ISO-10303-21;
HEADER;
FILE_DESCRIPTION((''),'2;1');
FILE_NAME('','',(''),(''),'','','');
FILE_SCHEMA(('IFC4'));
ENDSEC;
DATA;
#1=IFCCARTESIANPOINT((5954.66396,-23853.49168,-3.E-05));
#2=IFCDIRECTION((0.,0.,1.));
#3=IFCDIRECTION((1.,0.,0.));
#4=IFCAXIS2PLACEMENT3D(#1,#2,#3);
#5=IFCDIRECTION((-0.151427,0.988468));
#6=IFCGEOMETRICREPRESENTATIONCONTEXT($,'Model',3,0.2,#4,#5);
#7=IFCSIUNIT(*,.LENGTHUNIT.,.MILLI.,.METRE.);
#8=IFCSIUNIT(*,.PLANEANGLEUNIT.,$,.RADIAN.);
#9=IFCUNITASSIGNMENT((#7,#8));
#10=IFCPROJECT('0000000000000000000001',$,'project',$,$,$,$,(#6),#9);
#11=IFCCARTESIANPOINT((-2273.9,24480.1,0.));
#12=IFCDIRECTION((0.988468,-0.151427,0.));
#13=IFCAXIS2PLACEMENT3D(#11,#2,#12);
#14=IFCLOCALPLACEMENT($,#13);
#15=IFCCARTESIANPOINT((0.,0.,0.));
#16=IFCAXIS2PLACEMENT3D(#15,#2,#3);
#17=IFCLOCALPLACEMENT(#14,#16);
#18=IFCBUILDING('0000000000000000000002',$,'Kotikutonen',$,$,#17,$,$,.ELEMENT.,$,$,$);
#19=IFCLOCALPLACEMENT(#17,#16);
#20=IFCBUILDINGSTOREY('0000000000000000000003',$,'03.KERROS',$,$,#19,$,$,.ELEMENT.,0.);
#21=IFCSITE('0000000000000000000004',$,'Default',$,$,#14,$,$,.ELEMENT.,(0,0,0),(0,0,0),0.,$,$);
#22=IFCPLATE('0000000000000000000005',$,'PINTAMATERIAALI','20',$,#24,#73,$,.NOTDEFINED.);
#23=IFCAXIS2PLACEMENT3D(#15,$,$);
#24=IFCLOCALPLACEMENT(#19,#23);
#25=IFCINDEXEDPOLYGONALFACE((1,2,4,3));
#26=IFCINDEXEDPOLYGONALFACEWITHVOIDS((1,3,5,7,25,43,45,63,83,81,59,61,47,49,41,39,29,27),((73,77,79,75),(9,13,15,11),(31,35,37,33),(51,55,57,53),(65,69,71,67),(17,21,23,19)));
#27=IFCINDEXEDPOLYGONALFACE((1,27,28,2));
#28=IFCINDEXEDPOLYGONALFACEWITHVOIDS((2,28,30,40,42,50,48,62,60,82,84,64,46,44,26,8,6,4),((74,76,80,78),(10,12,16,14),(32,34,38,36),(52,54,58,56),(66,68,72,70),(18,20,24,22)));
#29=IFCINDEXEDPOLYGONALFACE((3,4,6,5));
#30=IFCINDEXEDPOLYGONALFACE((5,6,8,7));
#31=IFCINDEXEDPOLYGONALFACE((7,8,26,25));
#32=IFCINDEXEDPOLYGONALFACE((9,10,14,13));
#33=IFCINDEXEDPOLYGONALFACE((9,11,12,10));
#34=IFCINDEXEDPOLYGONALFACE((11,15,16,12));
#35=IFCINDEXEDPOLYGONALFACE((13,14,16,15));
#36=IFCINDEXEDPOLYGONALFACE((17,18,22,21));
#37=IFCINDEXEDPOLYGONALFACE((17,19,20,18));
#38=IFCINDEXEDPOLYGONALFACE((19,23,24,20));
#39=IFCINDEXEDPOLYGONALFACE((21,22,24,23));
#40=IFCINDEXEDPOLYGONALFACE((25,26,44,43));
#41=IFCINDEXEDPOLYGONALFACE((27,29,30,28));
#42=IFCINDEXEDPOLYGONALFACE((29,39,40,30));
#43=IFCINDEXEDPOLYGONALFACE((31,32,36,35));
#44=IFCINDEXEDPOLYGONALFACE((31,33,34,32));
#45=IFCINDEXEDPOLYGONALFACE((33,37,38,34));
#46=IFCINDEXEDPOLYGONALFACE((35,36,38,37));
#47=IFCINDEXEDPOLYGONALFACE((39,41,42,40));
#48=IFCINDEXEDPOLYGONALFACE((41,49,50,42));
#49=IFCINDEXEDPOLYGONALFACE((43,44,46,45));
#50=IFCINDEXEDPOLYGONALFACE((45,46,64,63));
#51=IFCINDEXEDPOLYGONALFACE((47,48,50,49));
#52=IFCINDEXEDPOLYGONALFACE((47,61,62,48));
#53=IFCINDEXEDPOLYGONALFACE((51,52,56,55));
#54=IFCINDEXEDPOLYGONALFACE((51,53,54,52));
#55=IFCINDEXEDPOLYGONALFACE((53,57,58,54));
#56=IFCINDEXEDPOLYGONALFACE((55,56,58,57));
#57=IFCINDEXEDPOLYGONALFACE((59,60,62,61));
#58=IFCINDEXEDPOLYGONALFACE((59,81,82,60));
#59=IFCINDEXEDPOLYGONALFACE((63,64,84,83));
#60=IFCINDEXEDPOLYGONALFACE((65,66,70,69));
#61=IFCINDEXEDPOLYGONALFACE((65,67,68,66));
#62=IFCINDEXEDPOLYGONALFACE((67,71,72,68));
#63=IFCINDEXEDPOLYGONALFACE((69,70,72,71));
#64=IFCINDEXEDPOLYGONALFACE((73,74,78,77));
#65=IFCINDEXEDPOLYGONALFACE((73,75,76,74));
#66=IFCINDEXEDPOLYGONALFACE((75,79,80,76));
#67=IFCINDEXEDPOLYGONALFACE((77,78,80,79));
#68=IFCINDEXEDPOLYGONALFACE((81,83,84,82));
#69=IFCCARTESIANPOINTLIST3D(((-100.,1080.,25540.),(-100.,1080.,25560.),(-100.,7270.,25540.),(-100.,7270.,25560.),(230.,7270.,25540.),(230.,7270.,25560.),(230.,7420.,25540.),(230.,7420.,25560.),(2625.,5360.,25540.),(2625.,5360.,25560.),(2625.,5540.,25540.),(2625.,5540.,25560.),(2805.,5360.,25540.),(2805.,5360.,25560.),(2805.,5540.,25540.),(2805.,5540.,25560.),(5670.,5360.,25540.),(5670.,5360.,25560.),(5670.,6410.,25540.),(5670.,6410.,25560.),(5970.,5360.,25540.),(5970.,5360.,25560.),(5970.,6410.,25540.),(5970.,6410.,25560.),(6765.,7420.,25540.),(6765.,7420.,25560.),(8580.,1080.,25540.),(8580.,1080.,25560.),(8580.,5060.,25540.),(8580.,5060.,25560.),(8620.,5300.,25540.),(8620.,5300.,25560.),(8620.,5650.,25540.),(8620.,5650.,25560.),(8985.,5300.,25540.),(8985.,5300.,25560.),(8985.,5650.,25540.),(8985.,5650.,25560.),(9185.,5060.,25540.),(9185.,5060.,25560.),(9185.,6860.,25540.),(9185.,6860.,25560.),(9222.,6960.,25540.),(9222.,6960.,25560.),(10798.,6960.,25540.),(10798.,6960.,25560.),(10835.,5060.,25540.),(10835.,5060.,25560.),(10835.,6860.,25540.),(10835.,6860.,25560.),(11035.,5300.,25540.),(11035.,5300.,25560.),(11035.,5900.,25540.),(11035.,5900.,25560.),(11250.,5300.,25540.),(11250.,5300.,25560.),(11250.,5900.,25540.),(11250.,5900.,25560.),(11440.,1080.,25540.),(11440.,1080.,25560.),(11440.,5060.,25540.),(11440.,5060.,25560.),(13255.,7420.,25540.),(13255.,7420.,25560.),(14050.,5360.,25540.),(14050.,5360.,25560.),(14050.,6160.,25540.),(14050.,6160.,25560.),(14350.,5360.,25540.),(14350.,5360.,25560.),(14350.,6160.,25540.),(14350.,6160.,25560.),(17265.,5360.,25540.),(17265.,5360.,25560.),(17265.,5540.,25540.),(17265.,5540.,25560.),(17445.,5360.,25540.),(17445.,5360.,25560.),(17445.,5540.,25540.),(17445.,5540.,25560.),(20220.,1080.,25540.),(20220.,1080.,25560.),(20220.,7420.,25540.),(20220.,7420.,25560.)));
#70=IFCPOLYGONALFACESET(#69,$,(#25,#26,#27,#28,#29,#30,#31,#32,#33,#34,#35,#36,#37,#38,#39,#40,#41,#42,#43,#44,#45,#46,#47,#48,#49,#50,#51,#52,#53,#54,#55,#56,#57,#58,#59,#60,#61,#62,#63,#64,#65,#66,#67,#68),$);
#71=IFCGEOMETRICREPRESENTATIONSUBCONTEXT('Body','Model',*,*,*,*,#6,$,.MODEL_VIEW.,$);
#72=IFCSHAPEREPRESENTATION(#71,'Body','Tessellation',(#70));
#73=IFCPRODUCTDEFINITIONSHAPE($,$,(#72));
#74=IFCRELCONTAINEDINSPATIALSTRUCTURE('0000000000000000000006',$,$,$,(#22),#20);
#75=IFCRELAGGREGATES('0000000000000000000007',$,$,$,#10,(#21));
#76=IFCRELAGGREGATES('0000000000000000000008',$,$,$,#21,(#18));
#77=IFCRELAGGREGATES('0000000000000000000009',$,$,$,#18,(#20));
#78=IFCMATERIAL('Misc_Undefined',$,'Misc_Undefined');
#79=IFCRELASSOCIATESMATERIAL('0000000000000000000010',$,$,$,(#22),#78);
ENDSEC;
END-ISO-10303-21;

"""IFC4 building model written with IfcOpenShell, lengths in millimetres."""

from ifc_helpers import new_model, si_unit, direction, frame, origin_with_axes, place, context, subcontext, project, spatial, line, indexed_curve, outline, extrude, material, element, save


model = new_model("IFC4")

# Units and contexts
model_context = context("Model", 3, precision=0.2, world=frame((5954.66396, -23853.49168, -3e-05), z_axis=(0.0, 0.0, 1.0), x_axis=(1.0, 0.0, 0.0)), true_north=direction((-0.151427, 0.988468)))
body_context = subcontext(model_context, "Body", "Model", "MODEL_VIEW")
ifc_project = project(units=[si_unit("LENGTHUNIT", "METRE", prefix="MILLI"), si_unit("PLANEANGLEUNIT", "RADIAN")], contexts=[model_context])

# Site, building, storey
site_placement = place(None, frame((-2273.9, 24480.1, 0.0), z_axis=(0.0, 0.0, 1.0), x_axis=(0.988468, -0.151427, 0.0)))
site = spatial("IfcSite", under=ifc_project, at=site_placement, Name="Default", CompositionType="ELEMENT", RefLatitude=(0, 0, 0), RefLongitude=(0, 0, 0), RefElevation=0.0)
building_placement = place(site_placement, origin_with_axes())
building = spatial("IfcBuilding", under=site, at=building_placement, Name="Kotikutonen", CompositionType="ELEMENT")
storey_placement = place(building_placement, origin_with_axes())
storey = spatial("IfcBuildingStorey", under=building, at=storey_placement, Name="03.KERROS", CompositionType="ELEMENT", Elevation=0.0)

# Plate, voiding features
ifc_material_1 = material(Name="Misc_Undefined", Category="Misc_Undefined")
plate_placement = place(storey_placement, frame((-100.0, 7270.0, 25550.0), z_axis=(0.0, 0.0, 1.0), x_axis=(0.0, -1.0, 0.0)))
plate = element("IfcPlate", 1, at=plate_placement, inside=storey, material=ifc_material_1, Name="PINTAMATERIAALI", Description="20", PredefinedType="NOTDEFINED", context=body_context, shape_type="SolidModel", body=[
    extrude(outline(indexed_curve([(0.0, 0.0), (6190.0, 0.0), (6190.0, 8680.0), (7270.0, 8680.0), (7270.0, 11540.0), (6190.0, 11540.0), (6190.0, 20320.0), (-150.0, 20320.0), (-150.0, 13355.0), (310.0, 10898.0), (310.0, 9322.0), (-150.0, 6865.0), (-150.0, 330.0), (0.0, 330.0)], segments=[line(1, 2, 3, 4, 5, 6, 7, 8, 9, 10, 11, 12, 13, 14, 1)])), frame((0.0, 0.0, 10.0), z_axis=(0.0, 0.0, 1.0), x_axis=(1.0, 0.0, 0.0)), (0.0, 0.0, -1.0), 20.0),
])
voiding_feature_1_placement = place(plate_placement, frame((2210.0, 8680.0, 0.0), z_axis=(0.0, 0.0, 1.0), x_axis=(1.0, 0.0, 0.0)))
element("IfcVoidingFeature", 2, at=voiding_feature_1_placement, cuts=plate, Name="POLYGON CUT", PredefinedType="HOLE", context=body_context, shape_type="SolidModel", body=[
    extrude(outline(indexed_curve([(0.0, 0.0), (5060.0, 0.0), (5060.0, 2860.0), (0.0, 2860.0), (0.0, 2255.0), (-1800.0, 2255.0), (-1800.0, 605.0), (0.0, 605.0)], segments=[line(1, 2, 3, 4, 5, 6, 7, 8, 1)])), frame((0.0, 0.0, 85.0), z_axis=(0.0, 0.0, 1.0), x_axis=(1.0, 0.0, 0.0)), (0.0, 0.0, -1.0), 170.0),
])
voiding_feature_2_placement = place(plate_placement, frame((1620.0, 8720.0, 0.0), z_axis=(0.0, 0.0, 1.0), x_axis=(1.0, 0.0, 0.0)))
element("IfcVoidingFeature", 3, at=voiding_feature_2_placement, cuts=plate, Name="POLYGON CUT", PredefinedType="HOLE", context=body_context, shape_type="SolidModel", body=[
    extrude(outline(indexed_curve([(0.0, 0.0), (350.0, 0.0), (350.0, 365.0), (0.0, 365.0)], segments=[line(1, 2, 3, 4, 1)])), frame((0.0, 0.0, 85.0), z_axis=(0.0, 0.0, 1.0), x_axis=(1.0, 0.0, 0.0)), (0.0, 0.0, -1.0), 170.0),
])
voiding_feature_3_placement = place(plate_placement, frame((1370.0, 11135.0, 0.0), z_axis=(0.0, 0.0, 1.0), x_axis=(1.0, 0.0, 0.0)))
element("IfcVoidingFeature", 4, at=voiding_feature_3_placement, cuts=plate, Name="POLYGON CUT", PredefinedType="HOLE", context=body_context, shape_type="SolidModel", body=[
    extrude(outline(indexed_curve([(0.0, 0.0), (600.0, 0.0), (600.0, 215.0), (0.0, 215.0)], segments=[line(1, 2, 3, 4, 1)])), frame((0.0, 0.0, 85.0), z_axis=(0.0, 0.0, 1.0), x_axis=(1.0, 0.0, 0.0)), (0.0, 0.0, -1.0), 170.0),
])
voiding_feature_4_placement = place(plate_placement, frame((860.0, 5770.0, 0.0), z_axis=(0.0, 0.0, 1.0), x_axis=(1.0, 0.0, 0.0)))
element("IfcVoidingFeature", 5, at=voiding_feature_4_placement, cuts=plate, Name="POLYGON CUT", PredefinedType="HOLE", context=body_context, shape_type="SolidModel", body=[
    extrude(outline(indexed_curve([(0.0, 0.0), (1050.0, 0.0), (1050.0, 300.0), (0.0, 300.0)], segments=[line(1, 2, 3, 4, 1)])), frame((0.0, 0.0, 85.0), z_axis=(0.0, 0.0, 1.0), x_axis=(1.0, 0.0, 0.0)), (0.0, 0.0, -1.0), 170.0),
])
voiding_feature_5_placement = place(plate_placement, frame((1110.0, 14150.0, 0.0), z_axis=(0.0, 0.0, 1.0), x_axis=(1.0, 0.0, 0.0)))
element("IfcVoidingFeature", 6, at=voiding_feature_5_placement, cuts=plate, Name="POLYGON CUT", PredefinedType="HOLE", context=body_context, shape_type="SolidModel", body=[
    extrude(outline(indexed_curve([(0.0, 0.0), (800.0, 0.0), (800.0, 300.0), (0.0, 300.0)], segments=[line(1, 2, 3, 4, 1)])), frame((0.0, 0.0, 85.0), z_axis=(0.0, 0.0, 1.0), x_axis=(1.0, 0.0, 0.0)), (0.0, 0.0, -1.0), 170.0),
])
voiding_feature_6_placement = place(plate_placement, frame((1730.0, 2725.0, 0.0), z_axis=(0.0, 0.0, 1.0), x_axis=(1.0, 0.0, 0.0)))
element("IfcVoidingFeature", 7, at=voiding_feature_6_placement, cuts=plate, Name="POLYGON CUT", PredefinedType="HOLE", context=body_context, shape_type="SolidModel", body=[
    extrude(outline(indexed_curve([(0.0, 0.0), (180.0, 0.0), (180.0, 180.0), (0.0, 180.0)], segments=[line(1, 2, 3, 4, 1)])), frame((0.0, 0.0, 85.0), z_axis=(0.0, 0.0, 1.0), x_axis=(1.0, 0.0, 0.0)), (0.0, 0.0, -1.0), 170.0),
])
voiding_feature_7_placement = place(plate_placement, frame((1730.0, 17365.0, 0.0), z_axis=(0.0, 0.0, 1.0), x_axis=(1.0, 0.0, 0.0)))
element("IfcVoidingFeature", 8, at=voiding_feature_7_placement, cuts=plate, Name="POLYGON CUT", PredefinedType="HOLE", context=body_context, shape_type="SolidModel", body=[
    extrude(outline(indexed_curve([(0.0, 0.0), (180.0, 0.0), (180.0, 180.0), (0.0, 180.0)], segments=[line(1, 2, 3, 4, 1)])), frame((0.0, 0.0, 85.0), z_axis=(0.0, 0.0, 1.0), x_axis=(1.0, 0.0, 0.0)), (0.0, 0.0, -1.0), 170.0),
])

save(model, "model.ifc")
